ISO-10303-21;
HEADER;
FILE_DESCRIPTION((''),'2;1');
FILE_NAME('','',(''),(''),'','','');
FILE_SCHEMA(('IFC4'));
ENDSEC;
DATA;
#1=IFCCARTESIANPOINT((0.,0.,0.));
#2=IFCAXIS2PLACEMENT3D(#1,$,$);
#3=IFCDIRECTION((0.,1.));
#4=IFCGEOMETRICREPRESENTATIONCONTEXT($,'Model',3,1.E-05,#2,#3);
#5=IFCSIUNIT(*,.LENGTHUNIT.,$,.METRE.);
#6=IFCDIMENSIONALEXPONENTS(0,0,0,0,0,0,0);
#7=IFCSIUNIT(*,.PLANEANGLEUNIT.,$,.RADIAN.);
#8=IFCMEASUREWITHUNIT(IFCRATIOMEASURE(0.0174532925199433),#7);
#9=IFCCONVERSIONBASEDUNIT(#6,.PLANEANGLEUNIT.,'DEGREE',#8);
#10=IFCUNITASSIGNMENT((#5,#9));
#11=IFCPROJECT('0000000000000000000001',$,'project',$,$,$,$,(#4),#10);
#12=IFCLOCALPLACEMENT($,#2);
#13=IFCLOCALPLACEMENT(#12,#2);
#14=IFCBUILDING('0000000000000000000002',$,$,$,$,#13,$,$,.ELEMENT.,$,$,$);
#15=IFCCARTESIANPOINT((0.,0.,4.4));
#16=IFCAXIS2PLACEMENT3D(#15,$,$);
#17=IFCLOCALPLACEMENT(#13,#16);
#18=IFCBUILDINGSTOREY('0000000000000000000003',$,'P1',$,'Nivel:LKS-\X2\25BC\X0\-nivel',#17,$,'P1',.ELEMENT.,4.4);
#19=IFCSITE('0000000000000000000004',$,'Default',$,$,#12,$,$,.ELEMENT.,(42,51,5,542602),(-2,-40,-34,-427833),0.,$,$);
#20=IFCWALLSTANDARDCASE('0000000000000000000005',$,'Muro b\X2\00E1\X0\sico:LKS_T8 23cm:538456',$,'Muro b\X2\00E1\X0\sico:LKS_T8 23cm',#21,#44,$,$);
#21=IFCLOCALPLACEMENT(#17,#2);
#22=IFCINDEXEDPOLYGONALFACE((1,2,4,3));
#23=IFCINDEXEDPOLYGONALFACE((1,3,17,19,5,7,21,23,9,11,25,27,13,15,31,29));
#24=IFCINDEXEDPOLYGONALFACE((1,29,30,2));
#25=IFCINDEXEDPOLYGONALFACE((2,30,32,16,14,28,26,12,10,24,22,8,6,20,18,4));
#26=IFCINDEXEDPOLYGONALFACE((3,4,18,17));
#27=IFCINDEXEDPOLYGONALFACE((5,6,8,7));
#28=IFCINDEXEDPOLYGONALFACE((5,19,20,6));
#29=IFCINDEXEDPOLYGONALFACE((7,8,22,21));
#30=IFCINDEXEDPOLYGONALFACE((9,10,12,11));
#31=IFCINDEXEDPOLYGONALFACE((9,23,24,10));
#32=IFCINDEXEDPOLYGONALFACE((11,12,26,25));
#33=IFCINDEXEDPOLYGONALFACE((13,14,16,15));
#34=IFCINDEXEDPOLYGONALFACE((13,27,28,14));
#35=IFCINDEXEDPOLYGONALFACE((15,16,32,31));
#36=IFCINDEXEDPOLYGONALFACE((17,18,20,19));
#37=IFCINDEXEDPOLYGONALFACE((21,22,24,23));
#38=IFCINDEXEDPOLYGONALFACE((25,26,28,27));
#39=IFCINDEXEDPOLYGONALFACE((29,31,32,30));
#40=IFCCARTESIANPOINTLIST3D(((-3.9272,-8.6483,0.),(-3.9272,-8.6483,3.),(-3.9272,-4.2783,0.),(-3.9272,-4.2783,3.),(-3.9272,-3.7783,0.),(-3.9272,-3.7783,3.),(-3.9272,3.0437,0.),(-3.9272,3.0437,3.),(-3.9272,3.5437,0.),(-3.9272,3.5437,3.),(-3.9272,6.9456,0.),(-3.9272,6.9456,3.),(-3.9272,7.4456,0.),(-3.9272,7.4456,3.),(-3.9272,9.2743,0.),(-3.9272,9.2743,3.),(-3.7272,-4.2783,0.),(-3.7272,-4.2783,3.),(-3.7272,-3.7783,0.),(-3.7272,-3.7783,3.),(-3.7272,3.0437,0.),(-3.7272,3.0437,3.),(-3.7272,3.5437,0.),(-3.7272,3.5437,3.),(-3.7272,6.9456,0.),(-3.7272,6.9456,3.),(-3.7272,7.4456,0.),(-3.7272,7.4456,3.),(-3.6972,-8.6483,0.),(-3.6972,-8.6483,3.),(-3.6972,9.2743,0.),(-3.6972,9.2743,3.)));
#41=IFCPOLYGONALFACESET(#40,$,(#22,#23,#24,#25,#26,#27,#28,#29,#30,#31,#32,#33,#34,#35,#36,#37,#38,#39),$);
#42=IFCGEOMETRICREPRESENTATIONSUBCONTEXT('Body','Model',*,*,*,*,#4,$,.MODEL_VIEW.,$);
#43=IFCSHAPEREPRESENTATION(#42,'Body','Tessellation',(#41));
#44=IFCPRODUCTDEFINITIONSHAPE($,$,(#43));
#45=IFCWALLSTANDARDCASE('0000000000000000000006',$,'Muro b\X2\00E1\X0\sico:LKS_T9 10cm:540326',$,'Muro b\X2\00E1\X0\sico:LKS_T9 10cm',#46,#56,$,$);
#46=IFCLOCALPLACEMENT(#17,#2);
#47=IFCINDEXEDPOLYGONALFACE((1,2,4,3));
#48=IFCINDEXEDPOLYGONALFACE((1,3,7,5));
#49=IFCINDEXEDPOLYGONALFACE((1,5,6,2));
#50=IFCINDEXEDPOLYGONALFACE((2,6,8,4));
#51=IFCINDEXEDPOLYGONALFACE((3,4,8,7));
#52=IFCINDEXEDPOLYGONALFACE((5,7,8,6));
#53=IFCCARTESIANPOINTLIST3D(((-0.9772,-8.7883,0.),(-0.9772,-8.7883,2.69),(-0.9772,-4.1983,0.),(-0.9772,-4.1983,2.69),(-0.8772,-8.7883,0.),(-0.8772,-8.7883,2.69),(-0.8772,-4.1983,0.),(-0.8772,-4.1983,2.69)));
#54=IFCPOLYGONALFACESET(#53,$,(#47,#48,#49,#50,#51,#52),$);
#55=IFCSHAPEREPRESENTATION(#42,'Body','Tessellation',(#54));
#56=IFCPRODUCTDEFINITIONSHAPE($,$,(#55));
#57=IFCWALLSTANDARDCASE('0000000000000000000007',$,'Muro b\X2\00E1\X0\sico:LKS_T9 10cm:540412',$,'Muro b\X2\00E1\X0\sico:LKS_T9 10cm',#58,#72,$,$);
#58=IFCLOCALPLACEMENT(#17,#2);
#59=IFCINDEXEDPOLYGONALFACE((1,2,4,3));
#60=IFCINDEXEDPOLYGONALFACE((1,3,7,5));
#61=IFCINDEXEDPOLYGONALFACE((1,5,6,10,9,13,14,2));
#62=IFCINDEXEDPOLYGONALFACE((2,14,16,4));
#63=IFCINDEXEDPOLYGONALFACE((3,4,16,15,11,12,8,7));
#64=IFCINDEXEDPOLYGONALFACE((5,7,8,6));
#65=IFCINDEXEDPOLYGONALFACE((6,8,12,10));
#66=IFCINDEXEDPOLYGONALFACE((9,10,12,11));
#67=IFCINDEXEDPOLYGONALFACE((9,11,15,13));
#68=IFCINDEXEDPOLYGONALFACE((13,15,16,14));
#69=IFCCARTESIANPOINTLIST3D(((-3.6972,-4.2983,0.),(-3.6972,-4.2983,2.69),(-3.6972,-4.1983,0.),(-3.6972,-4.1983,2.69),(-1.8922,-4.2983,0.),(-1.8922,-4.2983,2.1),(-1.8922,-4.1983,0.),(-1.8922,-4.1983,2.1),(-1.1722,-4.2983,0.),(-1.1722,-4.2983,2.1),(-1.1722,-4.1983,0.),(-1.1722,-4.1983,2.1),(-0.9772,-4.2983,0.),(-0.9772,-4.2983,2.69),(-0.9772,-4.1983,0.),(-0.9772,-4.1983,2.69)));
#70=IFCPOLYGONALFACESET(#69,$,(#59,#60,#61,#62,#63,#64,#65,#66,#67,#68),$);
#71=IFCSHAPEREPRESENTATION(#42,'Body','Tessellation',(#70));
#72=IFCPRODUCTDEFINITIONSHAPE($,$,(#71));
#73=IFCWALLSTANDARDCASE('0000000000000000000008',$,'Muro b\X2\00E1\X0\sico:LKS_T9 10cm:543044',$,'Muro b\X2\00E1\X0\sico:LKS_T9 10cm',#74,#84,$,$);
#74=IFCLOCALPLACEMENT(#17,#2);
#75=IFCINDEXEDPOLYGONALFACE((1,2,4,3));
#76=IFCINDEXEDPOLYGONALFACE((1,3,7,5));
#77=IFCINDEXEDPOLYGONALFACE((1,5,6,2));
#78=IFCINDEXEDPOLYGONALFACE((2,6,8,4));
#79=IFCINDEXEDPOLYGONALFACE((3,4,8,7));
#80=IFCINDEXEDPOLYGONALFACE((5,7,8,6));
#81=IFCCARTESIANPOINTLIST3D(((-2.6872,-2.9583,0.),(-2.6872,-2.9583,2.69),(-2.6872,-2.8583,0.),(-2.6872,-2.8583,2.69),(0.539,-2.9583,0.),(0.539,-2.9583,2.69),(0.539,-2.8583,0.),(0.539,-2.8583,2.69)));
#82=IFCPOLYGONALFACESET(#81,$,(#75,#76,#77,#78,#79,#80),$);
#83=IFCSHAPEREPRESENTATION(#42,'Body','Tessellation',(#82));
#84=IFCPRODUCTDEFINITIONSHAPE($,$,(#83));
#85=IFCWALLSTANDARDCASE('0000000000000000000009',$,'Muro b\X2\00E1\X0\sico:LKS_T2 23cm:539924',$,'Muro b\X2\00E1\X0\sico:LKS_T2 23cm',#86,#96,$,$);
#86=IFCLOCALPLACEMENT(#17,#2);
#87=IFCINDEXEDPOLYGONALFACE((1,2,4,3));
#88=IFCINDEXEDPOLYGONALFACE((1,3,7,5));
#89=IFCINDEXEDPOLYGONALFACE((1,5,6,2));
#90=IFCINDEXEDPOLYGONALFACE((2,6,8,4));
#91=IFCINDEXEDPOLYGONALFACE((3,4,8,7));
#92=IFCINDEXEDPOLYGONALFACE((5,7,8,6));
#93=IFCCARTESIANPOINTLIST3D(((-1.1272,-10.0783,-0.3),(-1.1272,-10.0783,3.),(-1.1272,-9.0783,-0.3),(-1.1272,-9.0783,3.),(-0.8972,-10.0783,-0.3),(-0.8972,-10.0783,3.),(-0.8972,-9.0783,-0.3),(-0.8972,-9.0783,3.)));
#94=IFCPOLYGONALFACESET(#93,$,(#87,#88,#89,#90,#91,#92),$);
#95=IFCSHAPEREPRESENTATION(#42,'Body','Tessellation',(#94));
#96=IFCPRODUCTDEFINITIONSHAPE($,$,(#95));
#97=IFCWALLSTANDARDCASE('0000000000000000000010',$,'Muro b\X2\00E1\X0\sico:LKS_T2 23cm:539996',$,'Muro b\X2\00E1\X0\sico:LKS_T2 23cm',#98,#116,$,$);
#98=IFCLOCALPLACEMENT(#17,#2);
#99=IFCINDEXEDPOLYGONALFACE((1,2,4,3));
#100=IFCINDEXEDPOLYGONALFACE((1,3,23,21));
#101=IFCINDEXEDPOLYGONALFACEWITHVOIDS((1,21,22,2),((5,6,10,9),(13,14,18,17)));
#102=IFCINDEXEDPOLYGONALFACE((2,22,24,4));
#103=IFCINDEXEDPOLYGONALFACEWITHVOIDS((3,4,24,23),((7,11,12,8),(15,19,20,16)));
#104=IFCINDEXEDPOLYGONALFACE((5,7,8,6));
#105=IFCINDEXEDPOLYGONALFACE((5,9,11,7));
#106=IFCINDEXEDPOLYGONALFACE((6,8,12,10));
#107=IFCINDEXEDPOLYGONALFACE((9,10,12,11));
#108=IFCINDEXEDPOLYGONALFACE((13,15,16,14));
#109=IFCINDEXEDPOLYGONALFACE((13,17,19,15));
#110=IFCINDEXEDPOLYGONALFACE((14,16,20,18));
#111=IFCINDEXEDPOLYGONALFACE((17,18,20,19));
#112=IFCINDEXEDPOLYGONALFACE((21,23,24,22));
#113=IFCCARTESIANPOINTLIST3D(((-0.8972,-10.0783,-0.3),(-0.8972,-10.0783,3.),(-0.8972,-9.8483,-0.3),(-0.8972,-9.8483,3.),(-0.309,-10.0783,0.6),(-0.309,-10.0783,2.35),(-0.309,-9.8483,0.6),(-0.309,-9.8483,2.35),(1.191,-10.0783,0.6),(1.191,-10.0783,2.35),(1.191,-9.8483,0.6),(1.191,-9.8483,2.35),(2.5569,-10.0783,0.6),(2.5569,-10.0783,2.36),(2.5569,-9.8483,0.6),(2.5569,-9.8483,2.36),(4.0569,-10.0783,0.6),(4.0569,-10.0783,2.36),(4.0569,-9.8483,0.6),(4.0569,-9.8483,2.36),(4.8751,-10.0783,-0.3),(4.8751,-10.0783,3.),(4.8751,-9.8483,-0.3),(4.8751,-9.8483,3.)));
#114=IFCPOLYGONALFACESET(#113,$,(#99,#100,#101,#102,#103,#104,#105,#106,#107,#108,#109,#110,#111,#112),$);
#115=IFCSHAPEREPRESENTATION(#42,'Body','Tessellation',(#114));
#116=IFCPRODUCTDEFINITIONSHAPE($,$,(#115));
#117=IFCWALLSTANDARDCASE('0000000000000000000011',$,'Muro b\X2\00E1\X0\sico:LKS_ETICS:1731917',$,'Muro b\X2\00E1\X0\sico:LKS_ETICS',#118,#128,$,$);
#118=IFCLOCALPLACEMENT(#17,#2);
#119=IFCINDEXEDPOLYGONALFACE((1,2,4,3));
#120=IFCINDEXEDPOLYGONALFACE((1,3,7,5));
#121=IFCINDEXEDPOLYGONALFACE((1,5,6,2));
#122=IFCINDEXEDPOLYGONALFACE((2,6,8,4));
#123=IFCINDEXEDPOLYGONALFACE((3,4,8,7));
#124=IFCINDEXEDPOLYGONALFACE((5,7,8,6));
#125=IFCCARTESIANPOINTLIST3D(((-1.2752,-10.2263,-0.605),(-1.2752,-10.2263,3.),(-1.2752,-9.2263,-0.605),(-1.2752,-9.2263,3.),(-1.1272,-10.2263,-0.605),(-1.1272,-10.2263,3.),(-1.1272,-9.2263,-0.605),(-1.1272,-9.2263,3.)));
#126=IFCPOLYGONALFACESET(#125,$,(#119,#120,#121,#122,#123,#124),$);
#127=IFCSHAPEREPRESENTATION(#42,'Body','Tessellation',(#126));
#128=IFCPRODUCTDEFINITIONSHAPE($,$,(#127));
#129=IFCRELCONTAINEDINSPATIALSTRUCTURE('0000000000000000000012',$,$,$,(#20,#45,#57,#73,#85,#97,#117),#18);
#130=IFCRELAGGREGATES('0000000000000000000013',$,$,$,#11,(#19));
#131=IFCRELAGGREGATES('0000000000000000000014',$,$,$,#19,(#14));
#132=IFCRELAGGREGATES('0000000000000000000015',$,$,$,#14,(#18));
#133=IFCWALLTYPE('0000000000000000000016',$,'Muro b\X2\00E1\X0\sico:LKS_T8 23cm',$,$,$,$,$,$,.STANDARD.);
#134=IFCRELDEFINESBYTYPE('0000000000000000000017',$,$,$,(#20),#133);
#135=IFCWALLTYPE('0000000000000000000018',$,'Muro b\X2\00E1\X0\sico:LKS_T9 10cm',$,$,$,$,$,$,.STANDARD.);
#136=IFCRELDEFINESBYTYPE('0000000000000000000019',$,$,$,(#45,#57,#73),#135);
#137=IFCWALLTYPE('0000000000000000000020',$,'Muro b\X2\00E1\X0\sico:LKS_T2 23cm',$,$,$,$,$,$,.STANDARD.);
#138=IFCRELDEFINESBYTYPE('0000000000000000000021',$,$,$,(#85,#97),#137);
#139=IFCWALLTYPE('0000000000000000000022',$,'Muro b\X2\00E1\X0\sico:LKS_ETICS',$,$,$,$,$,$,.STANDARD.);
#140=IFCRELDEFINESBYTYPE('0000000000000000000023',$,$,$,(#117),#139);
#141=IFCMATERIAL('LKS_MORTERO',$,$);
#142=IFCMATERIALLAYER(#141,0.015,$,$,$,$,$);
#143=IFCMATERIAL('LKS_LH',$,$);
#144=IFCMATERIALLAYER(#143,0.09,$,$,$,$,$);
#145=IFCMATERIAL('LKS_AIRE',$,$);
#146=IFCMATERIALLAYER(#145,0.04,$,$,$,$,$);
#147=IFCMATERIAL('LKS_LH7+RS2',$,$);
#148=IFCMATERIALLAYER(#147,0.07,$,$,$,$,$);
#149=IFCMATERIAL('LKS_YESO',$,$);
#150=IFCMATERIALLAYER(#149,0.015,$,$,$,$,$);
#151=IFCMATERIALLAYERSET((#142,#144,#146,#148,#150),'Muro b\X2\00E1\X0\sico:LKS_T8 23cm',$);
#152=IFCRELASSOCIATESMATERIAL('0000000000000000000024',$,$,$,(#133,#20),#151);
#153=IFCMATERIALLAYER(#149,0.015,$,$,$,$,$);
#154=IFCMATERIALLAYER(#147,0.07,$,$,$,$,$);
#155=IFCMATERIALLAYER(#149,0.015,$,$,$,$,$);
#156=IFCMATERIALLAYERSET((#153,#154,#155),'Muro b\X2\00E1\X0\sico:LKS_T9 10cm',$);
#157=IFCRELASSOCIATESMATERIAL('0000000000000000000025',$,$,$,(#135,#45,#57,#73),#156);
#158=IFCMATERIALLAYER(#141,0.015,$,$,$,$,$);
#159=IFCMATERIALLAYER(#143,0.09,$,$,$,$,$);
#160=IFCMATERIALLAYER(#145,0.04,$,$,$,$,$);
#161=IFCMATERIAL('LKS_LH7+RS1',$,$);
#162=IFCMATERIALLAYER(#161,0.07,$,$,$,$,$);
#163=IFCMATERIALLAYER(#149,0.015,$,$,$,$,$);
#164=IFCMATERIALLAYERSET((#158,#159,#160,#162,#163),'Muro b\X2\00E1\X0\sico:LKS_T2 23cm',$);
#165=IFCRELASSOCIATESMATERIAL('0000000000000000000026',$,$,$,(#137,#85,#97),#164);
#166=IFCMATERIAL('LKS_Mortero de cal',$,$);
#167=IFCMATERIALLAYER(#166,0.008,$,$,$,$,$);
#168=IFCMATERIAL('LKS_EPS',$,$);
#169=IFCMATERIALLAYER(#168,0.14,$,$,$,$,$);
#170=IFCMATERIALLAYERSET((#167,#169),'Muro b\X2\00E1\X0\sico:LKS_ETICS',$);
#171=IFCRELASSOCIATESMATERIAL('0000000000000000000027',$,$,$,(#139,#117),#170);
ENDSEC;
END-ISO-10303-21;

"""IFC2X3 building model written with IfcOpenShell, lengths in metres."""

from ifc_helpers import new_model, entity, si_unit, converted_unit, direction, frame, frame_2d, origin, place, context, subcontext, project, spatial, polyline, rectangle, extrude, clip, bounded_halfspace, material, layer, layer_set, layer_usage, type_object, element, save


model = new_model("IFC2X3")

# Units and contexts
model_context = context("Model", 3, precision=1e-05, world=origin(), true_north=direction((0.0, 1.0)))
body_context = subcontext(model_context, "Body", "Model", "MODEL_VIEW")
ifc_project = project(units=[si_unit("LENGTHUNIT", "METRE"), converted_unit("PLANEANGLEUNIT", "DEGREE", entity("IfcRatioMeasure", 0.0174532925199433), si_unit("PLANEANGLEUNIT", "RADIAN"), dimensions=[0, 0, 0, 0, 0, 0, 0])], contexts=[model_context])

# Site, building, storey
site_placement = place(None, origin())
site = spatial("IfcSite", under=ifc_project, at=site_placement, Name="Default", CompositionType="ELEMENT", RefLatitude=(42, 51, 5, 542602), RefLongitude=(-2, -40, -34, -427833), RefElevation=0.0)
building_placement = place(site_placement, origin())
building = spatial("IfcBuilding", under=site, at=building_placement, CompositionType="ELEMENT")
storey_placement = place(building_placement, frame((0.0, 0.0, 4.4)))
storey = spatial("IfcBuildingStorey", under=building, at=storey_placement, Name="P1", ObjectType="Nivel:LKS-▼-nivel", LongName="P1", CompositionType="ELEMENT", Elevation=4.4)

# Shared definitions
ifc_material_1 = material(Name="LKS_MORTERO")
ifc_material_2 = material(Name="LKS_AIRE")

# Wall, openings
ifc_layer_1 = layer(ifc_material_1, 0.015)
ifc_material_3 = material(Name="LKS_LH")
ifc_layer_2 = layer(ifc_material_3, 0.09)
ifc_layer_3 = layer(ifc_material_2, 0.04)
ifc_material_4 = material(Name="LKS_LH7+RS2")
ifc_layer_4 = layer(ifc_material_4, 0.07)
ifc_material_5 = material(Name="LKS_YESO")
ifc_layer_5 = layer(ifc_material_5, 0.015)
ifc_layer_set_1 = layer_set([ifc_layer_1, ifc_layer_2, ifc_layer_3, ifc_layer_4, ifc_layer_5], Name="Muro básico:LKS_T8 23cm")
ifc_layer_usage_1 = layer_usage(ifc_layer_set_1, "AXIS2", "NEGATIVE", 0.115)
wall_type_1 = type_object("IfcWallType", Name="Muro básico:LKS_T8 23cm", PredefinedType="STANDARD", material=ifc_layer_set_1)
wall_1_placement = place(storey_placement, frame((-3.8122, -8.6483, 0.0), z_axis=(0.0, 0.0, 1.0), x_axis=(0.0, 1.0, 0.0)))
wall_1 = element("IfcWallStandardCase", 1, at=wall_1_placement, inside=storey, type_object=wall_type_1, material=ifc_layer_usage_1, Name="Muro básico:LKS_T8 23cm:538456", ObjectType="Muro básico:LKS_T8 23cm", context=body_context, shape_type="Clipping", body=[
    clip(extrude(rectangle(XDim=17.9225, YDim=0.23, at=frame_2d((8.9613, 0.0), x_axis=(-1.0, 0.0))), origin(), (0.0, 0.0, 1.0), 3.0), bounded_halfspace(frame((0.0, -0.115, 0.0), z_axis=(1.0, 0.0, 0.0), x_axis=(0.0, 0.0, -1.0)), True, frame((0.0, -0.115, 0.0), z_axis=(1.0, 0.0, 0.0), x_axis=(0.0, 0.0, -1.0)), polyline([(0.0, 0.0), (0.0, 0.23), (-2.67, 0.23), (-3.0, 0.23), (-3.0, 0.0), (0.0, 0.0)]))),
])
opening_1_placement = place(storey_placement, frame((-3.8122, -8.6483, 0.0), z_axis=(0.0, 0.0, 1.0), x_axis=(0.0, 1.0, 0.0)))
element("IfcOpeningElement", 2, at=opening_1_placement, cuts=wall_1, ObjectType="Opening", context=body_context, shape_type="SweptSolid", body=[
    extrude(rectangle(XDim=3.0, YDim=0.2, at=frame_2d((0.39, 0.0), x_axis=(1.0, 0.0))), frame((4.37, 0.015, 1.89), z_axis=(1.0, 0.0, 0.0), x_axis=(0.0, 0.0, -1.0)), (0.0, 0.0, 1.0), 0.5),
])
opening_2_placement = place(storey_placement, frame((-3.8122, -8.6483, 0.0), z_axis=(0.0, 0.0, 1.0), x_axis=(0.0, 1.0, 0.0)))
element("IfcOpeningElement", 3, at=opening_2_placement, cuts=wall_1, ObjectType="Opening", context=body_context, shape_type="SweptSolid", body=[
    extrude(rectangle(XDim=3.0, YDim=0.2, at=frame_2d((0.39, 0.0), x_axis=(1.0, 0.0))), frame((11.692, 0.015, 1.89), z_axis=(1.0, 0.0, 0.0), x_axis=(0.0, 0.0, -1.0)), (0.0, 0.0, 1.0), 0.5),
])
opening_3_placement = place(storey_placement, frame((-3.8122, -8.6483, 0.0), z_axis=(0.0, 0.0, 1.0), x_axis=(0.0, 1.0, 0.0)))
element("IfcOpeningElement", 4, at=opening_3_placement, cuts=wall_1, ObjectType="Opening", context=body_context, shape_type="SweptSolid", body=[
    extrude(rectangle(XDim=3.0, YDim=0.2, at=frame_2d((0.39, 0.0), x_axis=(1.0, 0.0))), frame((15.5939, 0.015, 1.89), z_axis=(1.0, 0.0, 0.0), x_axis=(0.0, 0.0, -1.0)), (0.0, 0.0, 1.0), 0.5),
])

# Wall
ifc_layer_6 = layer(ifc_material_5, 0.015)
ifc_layer_7 = layer(ifc_material_4, 0.07)
ifc_layer_8 = layer(ifc_material_5, 0.015)
ifc_layer_set_2 = layer_set([ifc_layer_6, ifc_layer_7, ifc_layer_8], Name="Muro básico:LKS_T9 10cm")
ifc_layer_usage_2 = layer_usage(ifc_layer_set_2, "AXIS2", "POSITIVE", -0.05)
wall_type_2 = type_object("IfcWallType", Name="Muro básico:LKS_T9 10cm", PredefinedType="STANDARD", material=ifc_layer_set_2)
wall_2_placement = place(storey_placement, frame((-0.9272, -8.7883, 0.0), z_axis=(0.0, 0.0, 1.0), x_axis=(0.0, 1.0, 0.0)))
element("IfcWallStandardCase", 5, at=wall_2_placement, inside=storey, type_object=wall_type_2, material=ifc_layer_usage_2, Name="Muro básico:LKS_T9 10cm:540326", ObjectType="Muro básico:LKS_T9 10cm", context=body_context, shape_type="SweptSolid", body=[
    extrude(rectangle(XDim=4.59, YDim=0.1, at=frame_2d((2.295, 0.0), x_axis=(-1.0, 0.0))), origin(), (0.0, 0.0, 1.0), 2.69),
])

# Wall, opening
ifc_layer_usage_3 = layer_usage(ifc_layer_set_2, "AXIS2", "POSITIVE", -0.05)
wall_3_placement = place(storey_placement, frame((-0.9772, -4.2483, 0.0), z_axis=(0.0, 0.0, 1.0), x_axis=(-1.0, 0.0, 0.0)))
wall_3 = element("IfcWallStandardCase", 6, at=wall_3_placement, inside=storey, type_object=wall_type_2, material=ifc_layer_usage_3, Name="Muro básico:LKS_T9 10cm:540412", ObjectType="Muro básico:LKS_T9 10cm", context=body_context, shape_type="SweptSolid", body=[
    extrude(rectangle(XDim=2.72, YDim=0.1, at=frame_2d((1.36, 0.0), x_axis=(-1.0, 0.0))), origin(), (0.0, 0.0, 1.0), 2.69),
])
opening_4_placement = place(wall_3_placement, frame((0.195, -0.05, 0.0)))
element("IfcOpeningElement", 7, at=opening_4_placement, cuts=wall_3, ObjectType="Opening", context=body_context, shape_type="SweptSolid", body=[
    extrude(rectangle(XDim=2.1, YDim=0.72, at=frame_2d((1.05, 0.36), x_axis=(1.0, 0.0))), frame((0.0, 0.0, 0.0), z_axis=(0.0, 1.0, 0.0), x_axis=(0.0, 0.0, 1.0)), (0.0, 0.0, 1.0), 0.1),
])

# Walls
ifc_layer_usage_4 = layer_usage(ifc_layer_set_2, "AXIS2", "NEGATIVE", 0.05)
wall_4_placement = place(storey_placement, frame((-2.6872, -2.9083, 0.0)))
element("IfcWallStandardCase", 8, at=wall_4_placement, inside=storey, type_object=wall_type_2, material=ifc_layer_usage_4, Name="Muro básico:LKS_T9 10cm:543044", ObjectType="Muro básico:LKS_T9 10cm", context=body_context, shape_type="SweptSolid", body=[
    extrude(rectangle(XDim=3.2261, YDim=0.1, at=frame_2d((1.6131, 0.0), x_axis=(-1.0, 0.0))), origin(), (0.0, 0.0, 1.0), 2.69),
])
ifc_layer_9 = layer(ifc_material_1, 0.015)
ifc_layer_10 = layer(ifc_material_3, 0.09)
ifc_layer_11 = layer(ifc_material_2, 0.04)
ifc_material_6 = material(Name="LKS_LH7+RS1")
ifc_layer_12 = layer(ifc_material_6, 0.07)
ifc_layer_13 = layer(ifc_material_5, 0.015)
ifc_layer_set_3 = layer_set([ifc_layer_9, ifc_layer_10, ifc_layer_11, ifc_layer_12, ifc_layer_13], Name="Muro básico:LKS_T2 23cm")
ifc_layer_usage_5 = layer_usage(ifc_layer_set_3, "AXIS2", "POSITIVE", -0.115)
wall_type_3 = type_object("IfcWallType", Name="Muro básico:LKS_T2 23cm", PredefinedType="STANDARD", material=ifc_layer_set_3)
wall_5_placement = place(storey_placement, frame((-1.0122, -9.0783, -0.3), z_axis=(0.0, 0.0, 1.0), x_axis=(0.0, -1.0, 0.0)))
element("IfcWallStandardCase", 9, at=wall_5_placement, inside=storey, type_object=wall_type_3, material=ifc_layer_usage_5, Name="Muro básico:LKS_T2 23cm:539924", ObjectType="Muro básico:LKS_T2 23cm", context=body_context, shape_type="SweptSolid", body=[
    extrude(rectangle(XDim=1.0, YDim=0.23, at=frame_2d((0.5, 0.0), x_axis=(-1.0, 0.0))), origin(), (0.0, 0.0, 1.0), 3.3),
])

# Wall, openings
ifc_layer_usage_6 = layer_usage(ifc_layer_set_3, "AXIS2", "POSITIVE", -0.115)
wall_6_placement = place(storey_placement, frame((-0.8972, -9.9633, -0.3)))
wall_6 = element("IfcWallStandardCase", 10, at=wall_6_placement, inside=storey, type_object=wall_type_3, material=ifc_layer_usage_6, Name="Muro básico:LKS_T2 23cm:539996", ObjectType="Muro básico:LKS_T2 23cm", context=body_context, shape_type="SweptSolid", body=[
    extrude(rectangle(XDim=5.7722, YDim=0.23, at=frame_2d((2.8861, 0.0), x_axis=(-1.0, 0.0))), origin(), (0.0, 0.0, 1.0), 3.3),
])
opening_5_placement = place(wall_6_placement, frame((2.0881, 0.115, 0.9)))
element("IfcOpeningElement", 11, at=opening_5_placement, cuts=wall_6, ObjectType="Opening", context=body_context, shape_type="SweptSolid", body=[
    extrude(rectangle(XDim=1.75, YDim=1.5, at=frame_2d((0.875, 0.75), x_axis=(1.0, 0.0))), frame((0.0, 0.0, 0.0), z_axis=(0.0, -1.0, 0.0), x_axis=(0.0, 0.0, 1.0)), (0.0, 0.0, 1.0), 0.23),
])
opening_6_placement = place(wall_6_placement, frame((4.9541, 0.115, 0.9)))
element("IfcOpeningElement", 12, at=opening_6_placement, cuts=wall_6, ObjectType="Opening", context=body_context, shape_type="SweptSolid", body=[
    extrude(rectangle(XDim=1.76, YDim=1.5, at=frame_2d((0.88, 0.75), x_axis=(1.0, 0.0))), frame((0.0, 0.0, 0.0), z_axis=(0.0, -1.0, 0.0), x_axis=(0.0, 0.0, 1.0)), (0.0, 0.0, 1.0), 0.23),
])

# Wall
ifc_material_7 = material(Name="LKS_Mortero de cal")
ifc_layer_14 = layer(ifc_material_7, 0.008)
ifc_material_8 = material(Name="LKS_EPS")
ifc_layer_15 = layer(ifc_material_8, 0.14)
ifc_layer_set_4 = layer_set([ifc_layer_14, ifc_layer_15], Name="Muro básico:LKS_ETICS")
ifc_layer_usage_7 = layer_usage(ifc_layer_set_4, "AXIS2", "POSITIVE", -0.074)
wall_type_4 = type_object("IfcWallType", Name="Muro básico:LKS_ETICS", PredefinedType="STANDARD", material=ifc_layer_set_4)
wall_7_placement = place(storey_placement, frame((-1.2012, -9.2263, -0.605), z_axis=(0.0, 0.0, 1.0), x_axis=(0.0, -1.0, 0.0)))
element("IfcWallStandardCase", 13, at=wall_7_placement, inside=storey, type_object=wall_type_4, material=ifc_layer_usage_7, Name="Muro básico:LKS_ETICS:1731917", ObjectType="Muro básico:LKS_ETICS", context=body_context, shape_type="SweptSolid", body=[
    extrude(rectangle(XDim=1.0, YDim=0.148, at=frame_2d((0.5, 0.0), x_axis=(-1.0, 0.0))), origin(), (0.0, 0.0, 1.0), 3.605),
])

save(model, "model.ifc")
